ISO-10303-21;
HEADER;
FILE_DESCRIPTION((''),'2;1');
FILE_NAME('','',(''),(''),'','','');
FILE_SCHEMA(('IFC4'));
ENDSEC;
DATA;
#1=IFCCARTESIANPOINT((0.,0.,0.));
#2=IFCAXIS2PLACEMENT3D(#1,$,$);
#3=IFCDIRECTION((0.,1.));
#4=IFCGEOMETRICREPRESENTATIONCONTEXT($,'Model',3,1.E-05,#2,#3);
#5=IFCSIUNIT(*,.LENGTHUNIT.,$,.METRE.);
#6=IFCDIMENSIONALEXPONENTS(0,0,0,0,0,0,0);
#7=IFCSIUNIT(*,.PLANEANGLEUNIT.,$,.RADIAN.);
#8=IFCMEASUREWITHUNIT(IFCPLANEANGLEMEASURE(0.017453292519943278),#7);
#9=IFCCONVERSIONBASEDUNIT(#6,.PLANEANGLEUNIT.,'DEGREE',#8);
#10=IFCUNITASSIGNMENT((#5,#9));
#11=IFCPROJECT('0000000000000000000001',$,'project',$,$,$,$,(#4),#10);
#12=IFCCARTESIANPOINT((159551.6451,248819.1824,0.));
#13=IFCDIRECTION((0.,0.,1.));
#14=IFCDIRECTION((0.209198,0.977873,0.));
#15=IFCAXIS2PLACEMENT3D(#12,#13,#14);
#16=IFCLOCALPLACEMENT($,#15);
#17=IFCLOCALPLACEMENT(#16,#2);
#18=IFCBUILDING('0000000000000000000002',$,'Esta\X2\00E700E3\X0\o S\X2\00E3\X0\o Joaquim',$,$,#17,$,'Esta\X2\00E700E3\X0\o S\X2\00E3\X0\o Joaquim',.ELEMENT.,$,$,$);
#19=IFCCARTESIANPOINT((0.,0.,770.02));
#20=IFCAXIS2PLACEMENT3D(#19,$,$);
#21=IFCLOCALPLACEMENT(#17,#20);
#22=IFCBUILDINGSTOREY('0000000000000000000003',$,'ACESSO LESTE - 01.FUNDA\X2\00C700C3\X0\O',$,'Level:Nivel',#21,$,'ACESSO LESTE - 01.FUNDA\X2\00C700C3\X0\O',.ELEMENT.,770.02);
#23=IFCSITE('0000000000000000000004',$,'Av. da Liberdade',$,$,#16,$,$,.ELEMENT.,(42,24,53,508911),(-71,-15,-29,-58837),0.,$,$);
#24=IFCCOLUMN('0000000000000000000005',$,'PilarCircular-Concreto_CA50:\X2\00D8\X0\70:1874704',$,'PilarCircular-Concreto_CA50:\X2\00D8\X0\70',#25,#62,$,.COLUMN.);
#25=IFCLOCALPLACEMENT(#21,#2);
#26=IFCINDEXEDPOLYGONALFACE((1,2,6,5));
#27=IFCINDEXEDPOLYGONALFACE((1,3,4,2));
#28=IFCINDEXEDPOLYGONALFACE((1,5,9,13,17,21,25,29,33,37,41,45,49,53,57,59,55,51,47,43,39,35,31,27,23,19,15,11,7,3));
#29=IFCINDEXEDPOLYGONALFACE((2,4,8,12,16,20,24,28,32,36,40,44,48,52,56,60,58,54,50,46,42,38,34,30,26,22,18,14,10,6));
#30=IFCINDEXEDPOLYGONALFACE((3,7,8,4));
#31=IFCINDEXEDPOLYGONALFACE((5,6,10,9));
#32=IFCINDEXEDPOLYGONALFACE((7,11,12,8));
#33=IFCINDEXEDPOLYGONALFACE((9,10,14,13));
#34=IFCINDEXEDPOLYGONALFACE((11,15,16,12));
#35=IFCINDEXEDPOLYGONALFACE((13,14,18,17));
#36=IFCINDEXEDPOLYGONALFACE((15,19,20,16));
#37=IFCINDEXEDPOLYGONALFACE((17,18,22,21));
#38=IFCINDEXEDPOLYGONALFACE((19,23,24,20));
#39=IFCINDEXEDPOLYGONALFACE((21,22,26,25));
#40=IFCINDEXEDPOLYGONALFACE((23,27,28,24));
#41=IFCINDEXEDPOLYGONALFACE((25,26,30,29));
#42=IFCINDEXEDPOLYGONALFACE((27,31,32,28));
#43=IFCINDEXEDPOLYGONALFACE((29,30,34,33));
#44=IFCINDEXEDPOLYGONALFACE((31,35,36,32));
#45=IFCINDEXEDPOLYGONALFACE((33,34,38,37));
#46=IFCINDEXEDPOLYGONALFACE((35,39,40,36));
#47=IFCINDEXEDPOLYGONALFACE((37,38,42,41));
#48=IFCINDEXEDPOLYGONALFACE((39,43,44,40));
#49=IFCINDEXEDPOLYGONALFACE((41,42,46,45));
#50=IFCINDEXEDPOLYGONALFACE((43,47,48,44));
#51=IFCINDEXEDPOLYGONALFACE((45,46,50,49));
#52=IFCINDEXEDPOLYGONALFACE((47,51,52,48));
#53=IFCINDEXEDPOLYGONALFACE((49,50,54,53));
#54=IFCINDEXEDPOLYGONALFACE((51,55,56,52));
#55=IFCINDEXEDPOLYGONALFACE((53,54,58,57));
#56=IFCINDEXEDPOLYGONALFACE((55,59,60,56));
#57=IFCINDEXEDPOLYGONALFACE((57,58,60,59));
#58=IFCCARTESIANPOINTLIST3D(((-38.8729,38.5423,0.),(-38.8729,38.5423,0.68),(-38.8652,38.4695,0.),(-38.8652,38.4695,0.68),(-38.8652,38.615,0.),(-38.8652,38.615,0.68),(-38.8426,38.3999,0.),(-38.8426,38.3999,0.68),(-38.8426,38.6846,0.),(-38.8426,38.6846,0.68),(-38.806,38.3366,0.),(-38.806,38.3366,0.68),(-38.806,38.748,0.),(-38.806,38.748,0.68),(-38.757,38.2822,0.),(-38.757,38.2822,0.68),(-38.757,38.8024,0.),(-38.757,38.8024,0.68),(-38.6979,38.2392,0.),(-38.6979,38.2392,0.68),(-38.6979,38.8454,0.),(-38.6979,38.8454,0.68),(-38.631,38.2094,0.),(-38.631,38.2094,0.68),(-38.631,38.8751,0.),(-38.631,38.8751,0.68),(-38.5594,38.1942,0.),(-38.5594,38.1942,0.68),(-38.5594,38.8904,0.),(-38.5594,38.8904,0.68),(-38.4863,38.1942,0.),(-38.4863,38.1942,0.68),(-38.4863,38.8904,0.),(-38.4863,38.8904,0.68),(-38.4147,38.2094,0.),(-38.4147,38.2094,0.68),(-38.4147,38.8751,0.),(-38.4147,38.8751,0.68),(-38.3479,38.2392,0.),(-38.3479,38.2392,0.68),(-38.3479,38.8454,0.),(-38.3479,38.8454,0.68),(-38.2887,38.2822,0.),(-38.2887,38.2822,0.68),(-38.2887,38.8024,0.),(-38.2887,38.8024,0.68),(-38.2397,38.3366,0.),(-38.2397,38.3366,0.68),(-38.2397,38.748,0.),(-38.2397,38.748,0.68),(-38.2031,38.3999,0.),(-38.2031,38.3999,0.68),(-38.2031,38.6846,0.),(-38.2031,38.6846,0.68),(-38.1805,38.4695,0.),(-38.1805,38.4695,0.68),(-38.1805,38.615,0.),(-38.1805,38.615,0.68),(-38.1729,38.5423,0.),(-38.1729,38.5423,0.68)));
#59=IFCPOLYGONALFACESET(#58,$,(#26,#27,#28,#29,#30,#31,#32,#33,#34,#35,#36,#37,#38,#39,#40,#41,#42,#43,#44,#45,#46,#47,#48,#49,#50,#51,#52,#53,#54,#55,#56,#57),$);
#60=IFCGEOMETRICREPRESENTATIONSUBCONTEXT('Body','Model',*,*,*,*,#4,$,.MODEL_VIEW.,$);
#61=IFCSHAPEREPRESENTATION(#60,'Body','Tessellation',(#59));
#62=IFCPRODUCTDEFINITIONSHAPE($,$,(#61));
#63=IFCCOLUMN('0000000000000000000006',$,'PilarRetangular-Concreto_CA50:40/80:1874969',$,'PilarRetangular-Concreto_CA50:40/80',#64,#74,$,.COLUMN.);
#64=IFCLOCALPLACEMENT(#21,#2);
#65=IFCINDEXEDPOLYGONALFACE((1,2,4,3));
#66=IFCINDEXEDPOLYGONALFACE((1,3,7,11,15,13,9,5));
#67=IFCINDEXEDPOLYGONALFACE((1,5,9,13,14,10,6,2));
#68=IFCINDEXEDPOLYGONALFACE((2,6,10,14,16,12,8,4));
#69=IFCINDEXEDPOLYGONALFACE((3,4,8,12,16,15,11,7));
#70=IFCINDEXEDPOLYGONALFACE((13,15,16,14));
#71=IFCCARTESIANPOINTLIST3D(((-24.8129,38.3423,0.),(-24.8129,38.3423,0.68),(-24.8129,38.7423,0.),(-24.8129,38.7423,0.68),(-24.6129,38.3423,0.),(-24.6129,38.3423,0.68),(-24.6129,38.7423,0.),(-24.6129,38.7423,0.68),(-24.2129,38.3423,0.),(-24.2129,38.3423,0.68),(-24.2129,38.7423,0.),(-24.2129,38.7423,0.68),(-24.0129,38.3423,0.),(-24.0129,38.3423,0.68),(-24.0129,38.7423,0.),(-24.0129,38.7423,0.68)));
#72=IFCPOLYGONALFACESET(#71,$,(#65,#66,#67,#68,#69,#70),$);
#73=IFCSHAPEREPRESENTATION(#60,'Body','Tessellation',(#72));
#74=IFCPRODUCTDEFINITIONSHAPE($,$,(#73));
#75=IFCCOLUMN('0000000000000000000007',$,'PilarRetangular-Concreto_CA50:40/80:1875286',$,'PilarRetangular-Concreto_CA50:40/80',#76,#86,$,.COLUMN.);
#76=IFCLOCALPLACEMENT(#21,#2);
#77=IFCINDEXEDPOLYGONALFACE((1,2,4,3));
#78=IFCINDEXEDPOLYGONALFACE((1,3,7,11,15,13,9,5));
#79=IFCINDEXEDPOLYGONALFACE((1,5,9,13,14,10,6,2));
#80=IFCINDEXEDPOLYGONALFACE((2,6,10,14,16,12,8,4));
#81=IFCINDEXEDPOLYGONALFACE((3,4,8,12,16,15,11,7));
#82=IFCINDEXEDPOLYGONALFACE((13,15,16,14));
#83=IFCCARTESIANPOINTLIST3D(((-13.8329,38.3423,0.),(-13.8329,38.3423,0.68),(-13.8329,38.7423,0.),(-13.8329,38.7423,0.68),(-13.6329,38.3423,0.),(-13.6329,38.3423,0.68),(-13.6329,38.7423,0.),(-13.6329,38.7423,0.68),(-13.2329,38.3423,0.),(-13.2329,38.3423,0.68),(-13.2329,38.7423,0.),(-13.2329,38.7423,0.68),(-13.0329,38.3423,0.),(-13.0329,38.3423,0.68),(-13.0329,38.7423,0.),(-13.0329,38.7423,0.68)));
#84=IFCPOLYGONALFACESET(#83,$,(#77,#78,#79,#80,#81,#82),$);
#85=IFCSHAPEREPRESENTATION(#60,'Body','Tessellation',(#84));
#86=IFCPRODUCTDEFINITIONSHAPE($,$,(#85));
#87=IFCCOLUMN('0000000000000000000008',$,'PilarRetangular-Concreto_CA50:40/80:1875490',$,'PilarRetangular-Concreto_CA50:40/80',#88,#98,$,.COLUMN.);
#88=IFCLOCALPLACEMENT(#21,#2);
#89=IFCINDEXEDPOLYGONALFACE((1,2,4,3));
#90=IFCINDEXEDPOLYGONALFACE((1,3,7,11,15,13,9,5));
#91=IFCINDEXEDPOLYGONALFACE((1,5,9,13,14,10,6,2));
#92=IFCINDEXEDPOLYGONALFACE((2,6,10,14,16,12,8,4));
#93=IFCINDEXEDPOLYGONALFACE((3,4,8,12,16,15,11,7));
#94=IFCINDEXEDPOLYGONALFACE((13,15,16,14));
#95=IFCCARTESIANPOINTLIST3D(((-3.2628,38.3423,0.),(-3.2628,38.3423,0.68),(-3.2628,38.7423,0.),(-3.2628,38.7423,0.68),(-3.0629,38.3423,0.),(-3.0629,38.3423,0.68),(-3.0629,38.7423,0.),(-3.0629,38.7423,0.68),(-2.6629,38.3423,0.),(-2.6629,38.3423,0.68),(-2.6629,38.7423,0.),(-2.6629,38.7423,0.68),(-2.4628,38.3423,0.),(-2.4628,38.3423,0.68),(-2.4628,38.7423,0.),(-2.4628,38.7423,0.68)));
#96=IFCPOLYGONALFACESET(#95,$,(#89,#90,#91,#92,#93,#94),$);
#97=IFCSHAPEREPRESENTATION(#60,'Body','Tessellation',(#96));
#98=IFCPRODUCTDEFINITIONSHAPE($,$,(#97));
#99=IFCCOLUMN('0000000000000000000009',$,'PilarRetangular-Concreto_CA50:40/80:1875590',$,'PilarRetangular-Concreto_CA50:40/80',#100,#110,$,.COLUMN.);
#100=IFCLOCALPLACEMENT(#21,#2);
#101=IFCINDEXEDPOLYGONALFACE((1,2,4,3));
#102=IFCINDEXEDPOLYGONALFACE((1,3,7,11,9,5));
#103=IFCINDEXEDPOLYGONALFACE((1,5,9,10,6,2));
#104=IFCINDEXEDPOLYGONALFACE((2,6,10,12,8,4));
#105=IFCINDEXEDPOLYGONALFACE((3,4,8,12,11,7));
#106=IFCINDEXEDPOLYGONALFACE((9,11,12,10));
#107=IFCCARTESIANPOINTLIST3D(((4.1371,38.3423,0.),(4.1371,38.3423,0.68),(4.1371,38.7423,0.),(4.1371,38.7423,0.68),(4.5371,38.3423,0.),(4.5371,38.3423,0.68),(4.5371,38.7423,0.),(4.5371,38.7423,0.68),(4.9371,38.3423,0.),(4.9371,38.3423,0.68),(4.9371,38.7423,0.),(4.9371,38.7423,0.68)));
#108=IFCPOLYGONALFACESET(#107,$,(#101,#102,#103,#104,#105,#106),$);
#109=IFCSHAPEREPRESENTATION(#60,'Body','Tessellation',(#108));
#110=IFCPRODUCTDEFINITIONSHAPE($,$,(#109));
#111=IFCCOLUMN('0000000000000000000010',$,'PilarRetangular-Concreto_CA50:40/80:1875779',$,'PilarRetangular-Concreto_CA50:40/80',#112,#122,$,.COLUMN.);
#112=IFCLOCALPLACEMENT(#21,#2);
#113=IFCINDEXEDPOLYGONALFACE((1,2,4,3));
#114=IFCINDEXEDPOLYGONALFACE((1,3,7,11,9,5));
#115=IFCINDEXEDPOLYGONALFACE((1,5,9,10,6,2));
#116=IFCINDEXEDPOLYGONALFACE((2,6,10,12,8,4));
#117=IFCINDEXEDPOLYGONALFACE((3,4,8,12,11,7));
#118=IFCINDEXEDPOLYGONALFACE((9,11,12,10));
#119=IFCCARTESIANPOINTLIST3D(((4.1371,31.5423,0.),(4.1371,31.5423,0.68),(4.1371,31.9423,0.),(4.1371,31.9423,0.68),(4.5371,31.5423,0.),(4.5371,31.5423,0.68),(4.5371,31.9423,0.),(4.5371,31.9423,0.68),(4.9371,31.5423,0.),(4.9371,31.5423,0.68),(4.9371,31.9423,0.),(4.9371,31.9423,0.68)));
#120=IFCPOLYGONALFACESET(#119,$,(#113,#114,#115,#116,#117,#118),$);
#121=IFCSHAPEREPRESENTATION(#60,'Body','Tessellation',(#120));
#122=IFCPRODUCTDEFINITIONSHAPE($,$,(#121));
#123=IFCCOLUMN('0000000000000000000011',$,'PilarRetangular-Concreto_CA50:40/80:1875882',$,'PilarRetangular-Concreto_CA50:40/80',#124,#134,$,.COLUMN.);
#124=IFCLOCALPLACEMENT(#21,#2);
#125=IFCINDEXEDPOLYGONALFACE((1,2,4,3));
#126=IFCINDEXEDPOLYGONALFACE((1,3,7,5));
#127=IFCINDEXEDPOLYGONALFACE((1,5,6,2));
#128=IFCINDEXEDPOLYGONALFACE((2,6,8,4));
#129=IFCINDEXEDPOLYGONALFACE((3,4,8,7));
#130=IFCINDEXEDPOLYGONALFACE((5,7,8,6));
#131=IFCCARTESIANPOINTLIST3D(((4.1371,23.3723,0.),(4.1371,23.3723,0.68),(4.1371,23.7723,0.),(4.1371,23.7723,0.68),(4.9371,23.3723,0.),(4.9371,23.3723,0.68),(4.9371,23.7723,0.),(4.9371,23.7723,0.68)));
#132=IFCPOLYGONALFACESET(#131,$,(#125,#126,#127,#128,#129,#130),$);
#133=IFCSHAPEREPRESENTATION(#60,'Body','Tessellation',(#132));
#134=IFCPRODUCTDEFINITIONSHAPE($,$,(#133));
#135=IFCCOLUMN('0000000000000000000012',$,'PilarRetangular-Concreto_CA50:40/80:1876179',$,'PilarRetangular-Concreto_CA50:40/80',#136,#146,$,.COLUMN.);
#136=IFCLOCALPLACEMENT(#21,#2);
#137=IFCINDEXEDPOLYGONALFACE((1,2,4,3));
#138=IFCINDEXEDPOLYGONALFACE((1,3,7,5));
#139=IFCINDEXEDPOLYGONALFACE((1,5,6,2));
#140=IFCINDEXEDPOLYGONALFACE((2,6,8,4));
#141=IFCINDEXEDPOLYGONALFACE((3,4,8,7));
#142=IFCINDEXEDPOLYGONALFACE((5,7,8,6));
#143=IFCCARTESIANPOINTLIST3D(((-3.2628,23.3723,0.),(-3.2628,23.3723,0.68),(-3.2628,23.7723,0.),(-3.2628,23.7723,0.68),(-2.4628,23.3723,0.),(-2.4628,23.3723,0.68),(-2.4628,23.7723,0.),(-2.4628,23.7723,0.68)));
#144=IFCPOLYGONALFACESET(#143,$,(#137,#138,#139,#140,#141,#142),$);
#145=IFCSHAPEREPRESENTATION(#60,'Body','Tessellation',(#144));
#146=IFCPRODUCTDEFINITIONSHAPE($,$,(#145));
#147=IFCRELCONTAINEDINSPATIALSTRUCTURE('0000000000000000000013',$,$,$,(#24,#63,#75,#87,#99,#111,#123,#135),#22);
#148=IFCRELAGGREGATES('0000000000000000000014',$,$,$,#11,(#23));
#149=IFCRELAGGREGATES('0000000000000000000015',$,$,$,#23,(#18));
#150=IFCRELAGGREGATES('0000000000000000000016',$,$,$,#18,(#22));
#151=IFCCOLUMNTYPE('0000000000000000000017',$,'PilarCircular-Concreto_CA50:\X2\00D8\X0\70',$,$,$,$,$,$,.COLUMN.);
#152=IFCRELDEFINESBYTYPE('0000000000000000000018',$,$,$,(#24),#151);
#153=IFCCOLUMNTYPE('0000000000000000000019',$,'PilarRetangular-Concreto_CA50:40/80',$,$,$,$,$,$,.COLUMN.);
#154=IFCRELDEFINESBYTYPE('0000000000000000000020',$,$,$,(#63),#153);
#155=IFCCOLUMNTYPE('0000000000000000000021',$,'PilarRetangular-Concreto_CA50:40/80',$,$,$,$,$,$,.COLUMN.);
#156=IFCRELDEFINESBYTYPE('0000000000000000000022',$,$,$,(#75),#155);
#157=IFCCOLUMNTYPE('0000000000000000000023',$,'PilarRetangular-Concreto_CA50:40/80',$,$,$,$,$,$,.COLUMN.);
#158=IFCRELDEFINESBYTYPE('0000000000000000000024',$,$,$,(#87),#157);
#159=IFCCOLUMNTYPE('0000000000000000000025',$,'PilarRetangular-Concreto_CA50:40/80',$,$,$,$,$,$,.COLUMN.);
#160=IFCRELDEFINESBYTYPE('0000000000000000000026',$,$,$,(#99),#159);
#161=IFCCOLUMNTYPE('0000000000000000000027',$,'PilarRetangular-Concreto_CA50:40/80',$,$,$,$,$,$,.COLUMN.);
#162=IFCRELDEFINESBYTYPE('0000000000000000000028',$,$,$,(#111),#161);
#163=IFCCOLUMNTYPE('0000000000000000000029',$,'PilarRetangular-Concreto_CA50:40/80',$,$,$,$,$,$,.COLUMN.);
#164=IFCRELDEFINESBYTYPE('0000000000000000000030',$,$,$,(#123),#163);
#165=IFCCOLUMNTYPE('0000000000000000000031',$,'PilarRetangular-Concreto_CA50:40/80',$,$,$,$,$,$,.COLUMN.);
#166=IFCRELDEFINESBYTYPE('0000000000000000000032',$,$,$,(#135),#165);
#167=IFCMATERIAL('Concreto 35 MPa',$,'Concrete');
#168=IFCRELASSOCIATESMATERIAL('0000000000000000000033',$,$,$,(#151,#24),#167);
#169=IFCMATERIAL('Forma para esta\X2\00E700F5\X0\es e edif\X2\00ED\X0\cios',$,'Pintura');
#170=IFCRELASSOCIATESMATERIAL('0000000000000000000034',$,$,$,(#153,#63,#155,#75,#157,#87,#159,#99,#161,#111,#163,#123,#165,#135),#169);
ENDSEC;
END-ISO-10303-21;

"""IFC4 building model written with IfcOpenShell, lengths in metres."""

from ifc_helpers import new_model, entity, si_unit, converted_unit, direction, frame, origin, place, context, subcontext, project, spatial, arc, indexed_curve, outline, extrude, source, transform, mapped, material, type_object, type_shapes, element, save


model = new_model("IFC4")

# Units and contexts
model_context = context("Model", 3, precision=1e-05, world=origin(), true_north=direction((0.0, 1.0)))
body_context = subcontext(model_context, "Body", "Model", "MODEL_VIEW")
ifc_project = project(units=[si_unit("LENGTHUNIT", "METRE"), converted_unit("PLANEANGLEUNIT", "DEGREE", entity("IfcPlaneAngleMeasure", 0.017453292519943278), si_unit("PLANEANGLEUNIT", "RADIAN"), dimensions=[0, 0, 0, 0, 0, 0, 0])], contexts=[model_context])

# Site, building, storey
site_placement = place(None, frame((159551.6451, 248819.1824, 0.0), z_axis=(0.0, 0.0, 1.0), x_axis=(0.209198, 0.977873, 0.0)))
site = spatial("IfcSite", under=ifc_project, at=site_placement, Name="Av. da Liberdade", CompositionType="ELEMENT", RefLatitude=(42, 24, 53, 508911), RefLongitude=(-71, -15, -29, -58837), RefElevation=0.0)
building_placement = place(site_placement, origin())
building = spatial("IfcBuilding", under=site, at=building_placement, Name="Estação São Joaquim", LongName="Estação São Joaquim", CompositionType="ELEMENT")
storey_placement = place(building_placement, frame((0.0, 0.0, 770.02)))
storey = spatial("IfcBuildingStorey", under=building, at=storey_placement, Name="ACESSO LESTE - 01.FUNDAÇÃO", ObjectType="Level:Nivel", LongName="ACESSO LESTE - 01.FUNDAÇÃO", CompositionType="ELEMENT", Elevation=770.02)

# Columns
ifc_material_1 = material(Name="Concreto 35 MPa", Category="Concrete")
column_type_1 = type_object("IfcColumnType", Name="PilarCircular-Concreto_CA50:Ø70", PredefinedType="COLUMN", material=ifc_material_1)
shared_shape_1 = source(origin(), body_context, "Body", "SweptSolid", [
    extrude(outline(indexed_curve([(-0.35, 0.0), (0.0, -0.35), (0.35, 0.0), (0.0, 0.35)], segments=[arc(1, 2, 3), arc(3, 4, 1)], self_intersect=False)), frame((-38.5229, 38.5423, 770.02)), (0.0, 0.0, 1.0), 0.68),
])
type_shapes(column_type_1, [shared_shape_1])
column_1_placement = place(storey_placement, frame((0.0, 0.0, -770.02)))
element("IfcColumn", 1, at=column_1_placement, inside=storey, type_object=column_type_1, material=ifc_material_1, Name="PilarCircular-Concreto_CA50:Ø70:1874704", ObjectType="PilarCircular-Concreto_CA50:Ø70", PredefinedType="COLUMN", context=body_context, shape_type="MappedRepresentation", body=[
    mapped(shared_shape_1, transform((0.0, 0.0, 0.0), scale=1.0)),
])
ifc_material_2 = material(Name="Forma para estações e edifícios", Category="Pintura")
column_type_2 = type_object("IfcColumnType", Name="PilarRetangular-Concreto_CA50:40/80", PredefinedType="COLUMN", material=ifc_material_2)
shared_shape_2 = source(origin(), body_context, "Body", "SweptSolid", [
    extrude(outline(indexed_curve([(-0.2, -0.4), (0.2, -0.4), (0.2, -0.2), (0.2, 0.2), (0.2, 0.4), (-0.2, 0.4), (-0.2, 0.2), (-0.2, -0.2), (-0.2, -0.4)], self_intersect=False)), frame((-24.4129, 38.5423, 770.02), z_axis=(0.0, 0.0, 1.0), x_axis=(0.0, -1.0, 0.0)), (0.0, 0.0, 1.0), 0.68),
])
type_shapes(column_type_2, [shared_shape_2])
column_2_placement = place(storey_placement, frame((0.0, 0.0, -770.02)))
element("IfcColumn", 2, at=column_2_placement, inside=storey, type_object=column_type_2, material=ifc_material_2, Name="PilarRetangular-Concreto_CA50:40/80:1874969", ObjectType="PilarRetangular-Concreto_CA50:40/80", PredefinedType="COLUMN", context=body_context, shape_type="MappedRepresentation", body=[
    mapped(shared_shape_2, transform((0.0, 0.0, 0.0), scale=1.0)),
])
column_type_3 = type_object("IfcColumnType", Name="PilarRetangular-Concreto_CA50:40/80", PredefinedType="COLUMN", material=ifc_material_2)
shared_shape_3 = source(origin(), body_context, "Body", "SweptSolid", [
    extrude(outline(indexed_curve([(-0.2, -0.4), (0.2, -0.4), (0.2, -0.2), (0.2, 0.2), (0.2, 0.4), (-0.2, 0.4), (-0.2, 0.2), (-0.2, -0.2), (-0.2, -0.4)], self_intersect=False)), frame((-13.4329, 38.5423, 770.02), z_axis=(0.0, 0.0, 1.0), x_axis=(0.0, 1.0, 0.0)), (0.0, 0.0, 1.0), 0.68),
])
type_shapes(column_type_3, [shared_shape_3])
column_3_placement = place(storey_placement, frame((0.0, 0.0, -770.02)))
element("IfcColumn", 3, at=column_3_placement, inside=storey, type_object=column_type_3, material=ifc_material_2, Name="PilarRetangular-Concreto_CA50:40/80:1875286", ObjectType="PilarRetangular-Concreto_CA50:40/80", PredefinedType="COLUMN", context=body_context, shape_type="MappedRepresentation", body=[
    mapped(shared_shape_3, transform((0.0, 0.0, 0.0), scale=1.0)),
])
column_type_4 = type_object("IfcColumnType", Name="PilarRetangular-Concreto_CA50:40/80", PredefinedType="COLUMN", material=ifc_material_2)
shared_shape_4 = source(origin(), body_context, "Body", "SweptSolid", [
    extrude(outline(indexed_curve([(-0.2, -0.4), (0.2, -0.4), (0.2, -0.2), (0.2, 0.2), (0.2, 0.4), (-0.2, 0.4), (-0.2, 0.2), (-0.2, -0.2), (-0.2, -0.4)], self_intersect=False)), frame((-2.8628, 38.5423, 770.02), z_axis=(0.0, 0.0, 1.0), x_axis=(0.0, 1.0, 0.0)), (0.0, 0.0, 1.0), 0.68),
])
type_shapes(column_type_4, [shared_shape_4])
column_4_placement = place(storey_placement, frame((0.0, 0.0, -770.02)))
element("IfcColumn", 4, at=column_4_placement, inside=storey, type_object=column_type_4, material=ifc_material_2, Name="PilarRetangular-Concreto_CA50:40/80:1875490", ObjectType="PilarRetangular-Concreto_CA50:40/80", PredefinedType="COLUMN", context=body_context, shape_type="MappedRepresentation", body=[
    mapped(shared_shape_4, transform((0.0, 0.0, 0.0), scale=1.0)),
])
column_type_5 = type_object("IfcColumnType", Name="PilarRetangular-Concreto_CA50:40/80", PredefinedType="COLUMN", material=ifc_material_2)
shared_shape_5 = source(origin(), body_context, "Body", "SweptSolid", [
    extrude(outline(indexed_curve([(-0.2, -0.4), (0.2, -0.4), (0.2, 0.0), (0.2, 0.4), (-0.2, 0.4), (-0.2, 0.0), (-0.2, -0.4)], self_intersect=False)), frame((4.5371, 38.5423, 770.02), z_axis=(0.0, 0.0, 1.0), x_axis=(0.0, 1.0, 0.0)), (0.0, 0.0, 1.0), 0.68),
])
type_shapes(column_type_5, [shared_shape_5])
column_5_placement = place(storey_placement, frame((0.0, 0.0, -770.02)))
element("IfcColumn", 5, at=column_5_placement, inside=storey, type_object=column_type_5, material=ifc_material_2, Name="PilarRetangular-Concreto_CA50:40/80:1875590", ObjectType="PilarRetangular-Concreto_CA50:40/80", PredefinedType="COLUMN", context=body_context, shape_type="MappedRepresentation", body=[
    mapped(shared_shape_5, transform((0.0, 0.0, 0.0), scale=1.0)),
])
column_type_6 = type_object("IfcColumnType", Name="PilarRetangular-Concreto_CA50:40/80", PredefinedType="COLUMN", material=ifc_material_2)
shared_shape_6 = source(origin(), body_context, "Body", "SweptSolid", [
    extrude(outline(indexed_curve([(-0.2, -0.4), (0.2, -0.4), (0.2, 0.0), (0.2, 0.4), (-0.2, 0.4), (-0.2, 0.0), (-0.2, -0.4)], self_intersect=False)), frame((4.5371, 31.7423, 770.02), z_axis=(0.0, 0.0, 1.0), x_axis=(0.0, -1.0, 0.0)), (0.0, 0.0, 1.0), 0.68),
])
type_shapes(column_type_6, [shared_shape_6])
column_6_placement = place(storey_placement, frame((0.0, 0.0, -770.02)))
element("IfcColumn", 6, at=column_6_placement, inside=storey, type_object=column_type_6, material=ifc_material_2, Name="PilarRetangular-Concreto_CA50:40/80:1875779", ObjectType="PilarRetangular-Concreto_CA50:40/80", PredefinedType="COLUMN", context=body_context, shape_type="MappedRepresentation", body=[
    mapped(shared_shape_6, transform((0.0, 0.0, 0.0), scale=1.0)),
])
column_type_7 = type_object("IfcColumnType", Name="PilarRetangular-Concreto_CA50:40/80", PredefinedType="COLUMN", material=ifc_material_2)
shared_shape_7 = source(origin(), body_context, "Body", "SweptSolid", [
    extrude(outline(indexed_curve([(-0.2, -0.4), (0.2, -0.4), (0.2, 0.4), (-0.2, 0.4), (-0.2, -0.4)], self_intersect=False)), frame((4.5371, 23.5723, 770.02), z_axis=(0.0, 0.0, 1.0), x_axis=(0.0, -1.0, 0.0)), (0.0, 0.0, 1.0), 0.68),
])
type_shapes(column_type_7, [shared_shape_7])
column_7_placement = place(storey_placement, frame((0.0, 0.0, -770.02)))
element("IfcColumn", 7, at=column_7_placement, inside=storey, type_object=column_type_7, material=ifc_material_2, Name="PilarRetangular-Concreto_CA50:40/80:1875882", ObjectType="PilarRetangular-Concreto_CA50:40/80", PredefinedType="COLUMN", context=body_context, shape_type="MappedRepresentation", body=[
    mapped(shared_shape_7, transform((0.0, 0.0, 0.0), scale=1.0)),
])
column_type_8 = type_object("IfcColumnType", Name="PilarRetangular-Concreto_CA50:40/80", PredefinedType="COLUMN", material=ifc_material_2)
shared_shape_8 = source(origin(), body_context, "Body", "SweptSolid", [
    extrude(outline(indexed_curve([(-0.2, -0.4), (0.2, -0.4), (0.2, 0.4), (-0.2, 0.4), (-0.2, -0.4)], self_intersect=False)), frame((-2.8628, 23.5723, 770.02), z_axis=(0.0, 0.0, 1.0), x_axis=(0.0, -1.0, 0.0)), (0.0, 0.0, 1.0), 0.68),
])
type_shapes(column_type_8, [shared_shape_8])
column_8_placement = place(storey_placement, frame((0.0, 0.0, -770.02)))
element("IfcColumn", 8, at=column_8_placement, inside=storey, type_object=column_type_8, material=ifc_material_2, Name="PilarRetangular-Concreto_CA50:40/80:1876179", ObjectType="PilarRetangular-Concreto_CA50:40/80", PredefinedType="COLUMN", context=body_context, shape_type="MappedRepresentation", body=[
    mapped(shared_shape_8, transform((0.0, 0.0, 0.0), scale=1.0)),
])

save(model, "model.ifc")
